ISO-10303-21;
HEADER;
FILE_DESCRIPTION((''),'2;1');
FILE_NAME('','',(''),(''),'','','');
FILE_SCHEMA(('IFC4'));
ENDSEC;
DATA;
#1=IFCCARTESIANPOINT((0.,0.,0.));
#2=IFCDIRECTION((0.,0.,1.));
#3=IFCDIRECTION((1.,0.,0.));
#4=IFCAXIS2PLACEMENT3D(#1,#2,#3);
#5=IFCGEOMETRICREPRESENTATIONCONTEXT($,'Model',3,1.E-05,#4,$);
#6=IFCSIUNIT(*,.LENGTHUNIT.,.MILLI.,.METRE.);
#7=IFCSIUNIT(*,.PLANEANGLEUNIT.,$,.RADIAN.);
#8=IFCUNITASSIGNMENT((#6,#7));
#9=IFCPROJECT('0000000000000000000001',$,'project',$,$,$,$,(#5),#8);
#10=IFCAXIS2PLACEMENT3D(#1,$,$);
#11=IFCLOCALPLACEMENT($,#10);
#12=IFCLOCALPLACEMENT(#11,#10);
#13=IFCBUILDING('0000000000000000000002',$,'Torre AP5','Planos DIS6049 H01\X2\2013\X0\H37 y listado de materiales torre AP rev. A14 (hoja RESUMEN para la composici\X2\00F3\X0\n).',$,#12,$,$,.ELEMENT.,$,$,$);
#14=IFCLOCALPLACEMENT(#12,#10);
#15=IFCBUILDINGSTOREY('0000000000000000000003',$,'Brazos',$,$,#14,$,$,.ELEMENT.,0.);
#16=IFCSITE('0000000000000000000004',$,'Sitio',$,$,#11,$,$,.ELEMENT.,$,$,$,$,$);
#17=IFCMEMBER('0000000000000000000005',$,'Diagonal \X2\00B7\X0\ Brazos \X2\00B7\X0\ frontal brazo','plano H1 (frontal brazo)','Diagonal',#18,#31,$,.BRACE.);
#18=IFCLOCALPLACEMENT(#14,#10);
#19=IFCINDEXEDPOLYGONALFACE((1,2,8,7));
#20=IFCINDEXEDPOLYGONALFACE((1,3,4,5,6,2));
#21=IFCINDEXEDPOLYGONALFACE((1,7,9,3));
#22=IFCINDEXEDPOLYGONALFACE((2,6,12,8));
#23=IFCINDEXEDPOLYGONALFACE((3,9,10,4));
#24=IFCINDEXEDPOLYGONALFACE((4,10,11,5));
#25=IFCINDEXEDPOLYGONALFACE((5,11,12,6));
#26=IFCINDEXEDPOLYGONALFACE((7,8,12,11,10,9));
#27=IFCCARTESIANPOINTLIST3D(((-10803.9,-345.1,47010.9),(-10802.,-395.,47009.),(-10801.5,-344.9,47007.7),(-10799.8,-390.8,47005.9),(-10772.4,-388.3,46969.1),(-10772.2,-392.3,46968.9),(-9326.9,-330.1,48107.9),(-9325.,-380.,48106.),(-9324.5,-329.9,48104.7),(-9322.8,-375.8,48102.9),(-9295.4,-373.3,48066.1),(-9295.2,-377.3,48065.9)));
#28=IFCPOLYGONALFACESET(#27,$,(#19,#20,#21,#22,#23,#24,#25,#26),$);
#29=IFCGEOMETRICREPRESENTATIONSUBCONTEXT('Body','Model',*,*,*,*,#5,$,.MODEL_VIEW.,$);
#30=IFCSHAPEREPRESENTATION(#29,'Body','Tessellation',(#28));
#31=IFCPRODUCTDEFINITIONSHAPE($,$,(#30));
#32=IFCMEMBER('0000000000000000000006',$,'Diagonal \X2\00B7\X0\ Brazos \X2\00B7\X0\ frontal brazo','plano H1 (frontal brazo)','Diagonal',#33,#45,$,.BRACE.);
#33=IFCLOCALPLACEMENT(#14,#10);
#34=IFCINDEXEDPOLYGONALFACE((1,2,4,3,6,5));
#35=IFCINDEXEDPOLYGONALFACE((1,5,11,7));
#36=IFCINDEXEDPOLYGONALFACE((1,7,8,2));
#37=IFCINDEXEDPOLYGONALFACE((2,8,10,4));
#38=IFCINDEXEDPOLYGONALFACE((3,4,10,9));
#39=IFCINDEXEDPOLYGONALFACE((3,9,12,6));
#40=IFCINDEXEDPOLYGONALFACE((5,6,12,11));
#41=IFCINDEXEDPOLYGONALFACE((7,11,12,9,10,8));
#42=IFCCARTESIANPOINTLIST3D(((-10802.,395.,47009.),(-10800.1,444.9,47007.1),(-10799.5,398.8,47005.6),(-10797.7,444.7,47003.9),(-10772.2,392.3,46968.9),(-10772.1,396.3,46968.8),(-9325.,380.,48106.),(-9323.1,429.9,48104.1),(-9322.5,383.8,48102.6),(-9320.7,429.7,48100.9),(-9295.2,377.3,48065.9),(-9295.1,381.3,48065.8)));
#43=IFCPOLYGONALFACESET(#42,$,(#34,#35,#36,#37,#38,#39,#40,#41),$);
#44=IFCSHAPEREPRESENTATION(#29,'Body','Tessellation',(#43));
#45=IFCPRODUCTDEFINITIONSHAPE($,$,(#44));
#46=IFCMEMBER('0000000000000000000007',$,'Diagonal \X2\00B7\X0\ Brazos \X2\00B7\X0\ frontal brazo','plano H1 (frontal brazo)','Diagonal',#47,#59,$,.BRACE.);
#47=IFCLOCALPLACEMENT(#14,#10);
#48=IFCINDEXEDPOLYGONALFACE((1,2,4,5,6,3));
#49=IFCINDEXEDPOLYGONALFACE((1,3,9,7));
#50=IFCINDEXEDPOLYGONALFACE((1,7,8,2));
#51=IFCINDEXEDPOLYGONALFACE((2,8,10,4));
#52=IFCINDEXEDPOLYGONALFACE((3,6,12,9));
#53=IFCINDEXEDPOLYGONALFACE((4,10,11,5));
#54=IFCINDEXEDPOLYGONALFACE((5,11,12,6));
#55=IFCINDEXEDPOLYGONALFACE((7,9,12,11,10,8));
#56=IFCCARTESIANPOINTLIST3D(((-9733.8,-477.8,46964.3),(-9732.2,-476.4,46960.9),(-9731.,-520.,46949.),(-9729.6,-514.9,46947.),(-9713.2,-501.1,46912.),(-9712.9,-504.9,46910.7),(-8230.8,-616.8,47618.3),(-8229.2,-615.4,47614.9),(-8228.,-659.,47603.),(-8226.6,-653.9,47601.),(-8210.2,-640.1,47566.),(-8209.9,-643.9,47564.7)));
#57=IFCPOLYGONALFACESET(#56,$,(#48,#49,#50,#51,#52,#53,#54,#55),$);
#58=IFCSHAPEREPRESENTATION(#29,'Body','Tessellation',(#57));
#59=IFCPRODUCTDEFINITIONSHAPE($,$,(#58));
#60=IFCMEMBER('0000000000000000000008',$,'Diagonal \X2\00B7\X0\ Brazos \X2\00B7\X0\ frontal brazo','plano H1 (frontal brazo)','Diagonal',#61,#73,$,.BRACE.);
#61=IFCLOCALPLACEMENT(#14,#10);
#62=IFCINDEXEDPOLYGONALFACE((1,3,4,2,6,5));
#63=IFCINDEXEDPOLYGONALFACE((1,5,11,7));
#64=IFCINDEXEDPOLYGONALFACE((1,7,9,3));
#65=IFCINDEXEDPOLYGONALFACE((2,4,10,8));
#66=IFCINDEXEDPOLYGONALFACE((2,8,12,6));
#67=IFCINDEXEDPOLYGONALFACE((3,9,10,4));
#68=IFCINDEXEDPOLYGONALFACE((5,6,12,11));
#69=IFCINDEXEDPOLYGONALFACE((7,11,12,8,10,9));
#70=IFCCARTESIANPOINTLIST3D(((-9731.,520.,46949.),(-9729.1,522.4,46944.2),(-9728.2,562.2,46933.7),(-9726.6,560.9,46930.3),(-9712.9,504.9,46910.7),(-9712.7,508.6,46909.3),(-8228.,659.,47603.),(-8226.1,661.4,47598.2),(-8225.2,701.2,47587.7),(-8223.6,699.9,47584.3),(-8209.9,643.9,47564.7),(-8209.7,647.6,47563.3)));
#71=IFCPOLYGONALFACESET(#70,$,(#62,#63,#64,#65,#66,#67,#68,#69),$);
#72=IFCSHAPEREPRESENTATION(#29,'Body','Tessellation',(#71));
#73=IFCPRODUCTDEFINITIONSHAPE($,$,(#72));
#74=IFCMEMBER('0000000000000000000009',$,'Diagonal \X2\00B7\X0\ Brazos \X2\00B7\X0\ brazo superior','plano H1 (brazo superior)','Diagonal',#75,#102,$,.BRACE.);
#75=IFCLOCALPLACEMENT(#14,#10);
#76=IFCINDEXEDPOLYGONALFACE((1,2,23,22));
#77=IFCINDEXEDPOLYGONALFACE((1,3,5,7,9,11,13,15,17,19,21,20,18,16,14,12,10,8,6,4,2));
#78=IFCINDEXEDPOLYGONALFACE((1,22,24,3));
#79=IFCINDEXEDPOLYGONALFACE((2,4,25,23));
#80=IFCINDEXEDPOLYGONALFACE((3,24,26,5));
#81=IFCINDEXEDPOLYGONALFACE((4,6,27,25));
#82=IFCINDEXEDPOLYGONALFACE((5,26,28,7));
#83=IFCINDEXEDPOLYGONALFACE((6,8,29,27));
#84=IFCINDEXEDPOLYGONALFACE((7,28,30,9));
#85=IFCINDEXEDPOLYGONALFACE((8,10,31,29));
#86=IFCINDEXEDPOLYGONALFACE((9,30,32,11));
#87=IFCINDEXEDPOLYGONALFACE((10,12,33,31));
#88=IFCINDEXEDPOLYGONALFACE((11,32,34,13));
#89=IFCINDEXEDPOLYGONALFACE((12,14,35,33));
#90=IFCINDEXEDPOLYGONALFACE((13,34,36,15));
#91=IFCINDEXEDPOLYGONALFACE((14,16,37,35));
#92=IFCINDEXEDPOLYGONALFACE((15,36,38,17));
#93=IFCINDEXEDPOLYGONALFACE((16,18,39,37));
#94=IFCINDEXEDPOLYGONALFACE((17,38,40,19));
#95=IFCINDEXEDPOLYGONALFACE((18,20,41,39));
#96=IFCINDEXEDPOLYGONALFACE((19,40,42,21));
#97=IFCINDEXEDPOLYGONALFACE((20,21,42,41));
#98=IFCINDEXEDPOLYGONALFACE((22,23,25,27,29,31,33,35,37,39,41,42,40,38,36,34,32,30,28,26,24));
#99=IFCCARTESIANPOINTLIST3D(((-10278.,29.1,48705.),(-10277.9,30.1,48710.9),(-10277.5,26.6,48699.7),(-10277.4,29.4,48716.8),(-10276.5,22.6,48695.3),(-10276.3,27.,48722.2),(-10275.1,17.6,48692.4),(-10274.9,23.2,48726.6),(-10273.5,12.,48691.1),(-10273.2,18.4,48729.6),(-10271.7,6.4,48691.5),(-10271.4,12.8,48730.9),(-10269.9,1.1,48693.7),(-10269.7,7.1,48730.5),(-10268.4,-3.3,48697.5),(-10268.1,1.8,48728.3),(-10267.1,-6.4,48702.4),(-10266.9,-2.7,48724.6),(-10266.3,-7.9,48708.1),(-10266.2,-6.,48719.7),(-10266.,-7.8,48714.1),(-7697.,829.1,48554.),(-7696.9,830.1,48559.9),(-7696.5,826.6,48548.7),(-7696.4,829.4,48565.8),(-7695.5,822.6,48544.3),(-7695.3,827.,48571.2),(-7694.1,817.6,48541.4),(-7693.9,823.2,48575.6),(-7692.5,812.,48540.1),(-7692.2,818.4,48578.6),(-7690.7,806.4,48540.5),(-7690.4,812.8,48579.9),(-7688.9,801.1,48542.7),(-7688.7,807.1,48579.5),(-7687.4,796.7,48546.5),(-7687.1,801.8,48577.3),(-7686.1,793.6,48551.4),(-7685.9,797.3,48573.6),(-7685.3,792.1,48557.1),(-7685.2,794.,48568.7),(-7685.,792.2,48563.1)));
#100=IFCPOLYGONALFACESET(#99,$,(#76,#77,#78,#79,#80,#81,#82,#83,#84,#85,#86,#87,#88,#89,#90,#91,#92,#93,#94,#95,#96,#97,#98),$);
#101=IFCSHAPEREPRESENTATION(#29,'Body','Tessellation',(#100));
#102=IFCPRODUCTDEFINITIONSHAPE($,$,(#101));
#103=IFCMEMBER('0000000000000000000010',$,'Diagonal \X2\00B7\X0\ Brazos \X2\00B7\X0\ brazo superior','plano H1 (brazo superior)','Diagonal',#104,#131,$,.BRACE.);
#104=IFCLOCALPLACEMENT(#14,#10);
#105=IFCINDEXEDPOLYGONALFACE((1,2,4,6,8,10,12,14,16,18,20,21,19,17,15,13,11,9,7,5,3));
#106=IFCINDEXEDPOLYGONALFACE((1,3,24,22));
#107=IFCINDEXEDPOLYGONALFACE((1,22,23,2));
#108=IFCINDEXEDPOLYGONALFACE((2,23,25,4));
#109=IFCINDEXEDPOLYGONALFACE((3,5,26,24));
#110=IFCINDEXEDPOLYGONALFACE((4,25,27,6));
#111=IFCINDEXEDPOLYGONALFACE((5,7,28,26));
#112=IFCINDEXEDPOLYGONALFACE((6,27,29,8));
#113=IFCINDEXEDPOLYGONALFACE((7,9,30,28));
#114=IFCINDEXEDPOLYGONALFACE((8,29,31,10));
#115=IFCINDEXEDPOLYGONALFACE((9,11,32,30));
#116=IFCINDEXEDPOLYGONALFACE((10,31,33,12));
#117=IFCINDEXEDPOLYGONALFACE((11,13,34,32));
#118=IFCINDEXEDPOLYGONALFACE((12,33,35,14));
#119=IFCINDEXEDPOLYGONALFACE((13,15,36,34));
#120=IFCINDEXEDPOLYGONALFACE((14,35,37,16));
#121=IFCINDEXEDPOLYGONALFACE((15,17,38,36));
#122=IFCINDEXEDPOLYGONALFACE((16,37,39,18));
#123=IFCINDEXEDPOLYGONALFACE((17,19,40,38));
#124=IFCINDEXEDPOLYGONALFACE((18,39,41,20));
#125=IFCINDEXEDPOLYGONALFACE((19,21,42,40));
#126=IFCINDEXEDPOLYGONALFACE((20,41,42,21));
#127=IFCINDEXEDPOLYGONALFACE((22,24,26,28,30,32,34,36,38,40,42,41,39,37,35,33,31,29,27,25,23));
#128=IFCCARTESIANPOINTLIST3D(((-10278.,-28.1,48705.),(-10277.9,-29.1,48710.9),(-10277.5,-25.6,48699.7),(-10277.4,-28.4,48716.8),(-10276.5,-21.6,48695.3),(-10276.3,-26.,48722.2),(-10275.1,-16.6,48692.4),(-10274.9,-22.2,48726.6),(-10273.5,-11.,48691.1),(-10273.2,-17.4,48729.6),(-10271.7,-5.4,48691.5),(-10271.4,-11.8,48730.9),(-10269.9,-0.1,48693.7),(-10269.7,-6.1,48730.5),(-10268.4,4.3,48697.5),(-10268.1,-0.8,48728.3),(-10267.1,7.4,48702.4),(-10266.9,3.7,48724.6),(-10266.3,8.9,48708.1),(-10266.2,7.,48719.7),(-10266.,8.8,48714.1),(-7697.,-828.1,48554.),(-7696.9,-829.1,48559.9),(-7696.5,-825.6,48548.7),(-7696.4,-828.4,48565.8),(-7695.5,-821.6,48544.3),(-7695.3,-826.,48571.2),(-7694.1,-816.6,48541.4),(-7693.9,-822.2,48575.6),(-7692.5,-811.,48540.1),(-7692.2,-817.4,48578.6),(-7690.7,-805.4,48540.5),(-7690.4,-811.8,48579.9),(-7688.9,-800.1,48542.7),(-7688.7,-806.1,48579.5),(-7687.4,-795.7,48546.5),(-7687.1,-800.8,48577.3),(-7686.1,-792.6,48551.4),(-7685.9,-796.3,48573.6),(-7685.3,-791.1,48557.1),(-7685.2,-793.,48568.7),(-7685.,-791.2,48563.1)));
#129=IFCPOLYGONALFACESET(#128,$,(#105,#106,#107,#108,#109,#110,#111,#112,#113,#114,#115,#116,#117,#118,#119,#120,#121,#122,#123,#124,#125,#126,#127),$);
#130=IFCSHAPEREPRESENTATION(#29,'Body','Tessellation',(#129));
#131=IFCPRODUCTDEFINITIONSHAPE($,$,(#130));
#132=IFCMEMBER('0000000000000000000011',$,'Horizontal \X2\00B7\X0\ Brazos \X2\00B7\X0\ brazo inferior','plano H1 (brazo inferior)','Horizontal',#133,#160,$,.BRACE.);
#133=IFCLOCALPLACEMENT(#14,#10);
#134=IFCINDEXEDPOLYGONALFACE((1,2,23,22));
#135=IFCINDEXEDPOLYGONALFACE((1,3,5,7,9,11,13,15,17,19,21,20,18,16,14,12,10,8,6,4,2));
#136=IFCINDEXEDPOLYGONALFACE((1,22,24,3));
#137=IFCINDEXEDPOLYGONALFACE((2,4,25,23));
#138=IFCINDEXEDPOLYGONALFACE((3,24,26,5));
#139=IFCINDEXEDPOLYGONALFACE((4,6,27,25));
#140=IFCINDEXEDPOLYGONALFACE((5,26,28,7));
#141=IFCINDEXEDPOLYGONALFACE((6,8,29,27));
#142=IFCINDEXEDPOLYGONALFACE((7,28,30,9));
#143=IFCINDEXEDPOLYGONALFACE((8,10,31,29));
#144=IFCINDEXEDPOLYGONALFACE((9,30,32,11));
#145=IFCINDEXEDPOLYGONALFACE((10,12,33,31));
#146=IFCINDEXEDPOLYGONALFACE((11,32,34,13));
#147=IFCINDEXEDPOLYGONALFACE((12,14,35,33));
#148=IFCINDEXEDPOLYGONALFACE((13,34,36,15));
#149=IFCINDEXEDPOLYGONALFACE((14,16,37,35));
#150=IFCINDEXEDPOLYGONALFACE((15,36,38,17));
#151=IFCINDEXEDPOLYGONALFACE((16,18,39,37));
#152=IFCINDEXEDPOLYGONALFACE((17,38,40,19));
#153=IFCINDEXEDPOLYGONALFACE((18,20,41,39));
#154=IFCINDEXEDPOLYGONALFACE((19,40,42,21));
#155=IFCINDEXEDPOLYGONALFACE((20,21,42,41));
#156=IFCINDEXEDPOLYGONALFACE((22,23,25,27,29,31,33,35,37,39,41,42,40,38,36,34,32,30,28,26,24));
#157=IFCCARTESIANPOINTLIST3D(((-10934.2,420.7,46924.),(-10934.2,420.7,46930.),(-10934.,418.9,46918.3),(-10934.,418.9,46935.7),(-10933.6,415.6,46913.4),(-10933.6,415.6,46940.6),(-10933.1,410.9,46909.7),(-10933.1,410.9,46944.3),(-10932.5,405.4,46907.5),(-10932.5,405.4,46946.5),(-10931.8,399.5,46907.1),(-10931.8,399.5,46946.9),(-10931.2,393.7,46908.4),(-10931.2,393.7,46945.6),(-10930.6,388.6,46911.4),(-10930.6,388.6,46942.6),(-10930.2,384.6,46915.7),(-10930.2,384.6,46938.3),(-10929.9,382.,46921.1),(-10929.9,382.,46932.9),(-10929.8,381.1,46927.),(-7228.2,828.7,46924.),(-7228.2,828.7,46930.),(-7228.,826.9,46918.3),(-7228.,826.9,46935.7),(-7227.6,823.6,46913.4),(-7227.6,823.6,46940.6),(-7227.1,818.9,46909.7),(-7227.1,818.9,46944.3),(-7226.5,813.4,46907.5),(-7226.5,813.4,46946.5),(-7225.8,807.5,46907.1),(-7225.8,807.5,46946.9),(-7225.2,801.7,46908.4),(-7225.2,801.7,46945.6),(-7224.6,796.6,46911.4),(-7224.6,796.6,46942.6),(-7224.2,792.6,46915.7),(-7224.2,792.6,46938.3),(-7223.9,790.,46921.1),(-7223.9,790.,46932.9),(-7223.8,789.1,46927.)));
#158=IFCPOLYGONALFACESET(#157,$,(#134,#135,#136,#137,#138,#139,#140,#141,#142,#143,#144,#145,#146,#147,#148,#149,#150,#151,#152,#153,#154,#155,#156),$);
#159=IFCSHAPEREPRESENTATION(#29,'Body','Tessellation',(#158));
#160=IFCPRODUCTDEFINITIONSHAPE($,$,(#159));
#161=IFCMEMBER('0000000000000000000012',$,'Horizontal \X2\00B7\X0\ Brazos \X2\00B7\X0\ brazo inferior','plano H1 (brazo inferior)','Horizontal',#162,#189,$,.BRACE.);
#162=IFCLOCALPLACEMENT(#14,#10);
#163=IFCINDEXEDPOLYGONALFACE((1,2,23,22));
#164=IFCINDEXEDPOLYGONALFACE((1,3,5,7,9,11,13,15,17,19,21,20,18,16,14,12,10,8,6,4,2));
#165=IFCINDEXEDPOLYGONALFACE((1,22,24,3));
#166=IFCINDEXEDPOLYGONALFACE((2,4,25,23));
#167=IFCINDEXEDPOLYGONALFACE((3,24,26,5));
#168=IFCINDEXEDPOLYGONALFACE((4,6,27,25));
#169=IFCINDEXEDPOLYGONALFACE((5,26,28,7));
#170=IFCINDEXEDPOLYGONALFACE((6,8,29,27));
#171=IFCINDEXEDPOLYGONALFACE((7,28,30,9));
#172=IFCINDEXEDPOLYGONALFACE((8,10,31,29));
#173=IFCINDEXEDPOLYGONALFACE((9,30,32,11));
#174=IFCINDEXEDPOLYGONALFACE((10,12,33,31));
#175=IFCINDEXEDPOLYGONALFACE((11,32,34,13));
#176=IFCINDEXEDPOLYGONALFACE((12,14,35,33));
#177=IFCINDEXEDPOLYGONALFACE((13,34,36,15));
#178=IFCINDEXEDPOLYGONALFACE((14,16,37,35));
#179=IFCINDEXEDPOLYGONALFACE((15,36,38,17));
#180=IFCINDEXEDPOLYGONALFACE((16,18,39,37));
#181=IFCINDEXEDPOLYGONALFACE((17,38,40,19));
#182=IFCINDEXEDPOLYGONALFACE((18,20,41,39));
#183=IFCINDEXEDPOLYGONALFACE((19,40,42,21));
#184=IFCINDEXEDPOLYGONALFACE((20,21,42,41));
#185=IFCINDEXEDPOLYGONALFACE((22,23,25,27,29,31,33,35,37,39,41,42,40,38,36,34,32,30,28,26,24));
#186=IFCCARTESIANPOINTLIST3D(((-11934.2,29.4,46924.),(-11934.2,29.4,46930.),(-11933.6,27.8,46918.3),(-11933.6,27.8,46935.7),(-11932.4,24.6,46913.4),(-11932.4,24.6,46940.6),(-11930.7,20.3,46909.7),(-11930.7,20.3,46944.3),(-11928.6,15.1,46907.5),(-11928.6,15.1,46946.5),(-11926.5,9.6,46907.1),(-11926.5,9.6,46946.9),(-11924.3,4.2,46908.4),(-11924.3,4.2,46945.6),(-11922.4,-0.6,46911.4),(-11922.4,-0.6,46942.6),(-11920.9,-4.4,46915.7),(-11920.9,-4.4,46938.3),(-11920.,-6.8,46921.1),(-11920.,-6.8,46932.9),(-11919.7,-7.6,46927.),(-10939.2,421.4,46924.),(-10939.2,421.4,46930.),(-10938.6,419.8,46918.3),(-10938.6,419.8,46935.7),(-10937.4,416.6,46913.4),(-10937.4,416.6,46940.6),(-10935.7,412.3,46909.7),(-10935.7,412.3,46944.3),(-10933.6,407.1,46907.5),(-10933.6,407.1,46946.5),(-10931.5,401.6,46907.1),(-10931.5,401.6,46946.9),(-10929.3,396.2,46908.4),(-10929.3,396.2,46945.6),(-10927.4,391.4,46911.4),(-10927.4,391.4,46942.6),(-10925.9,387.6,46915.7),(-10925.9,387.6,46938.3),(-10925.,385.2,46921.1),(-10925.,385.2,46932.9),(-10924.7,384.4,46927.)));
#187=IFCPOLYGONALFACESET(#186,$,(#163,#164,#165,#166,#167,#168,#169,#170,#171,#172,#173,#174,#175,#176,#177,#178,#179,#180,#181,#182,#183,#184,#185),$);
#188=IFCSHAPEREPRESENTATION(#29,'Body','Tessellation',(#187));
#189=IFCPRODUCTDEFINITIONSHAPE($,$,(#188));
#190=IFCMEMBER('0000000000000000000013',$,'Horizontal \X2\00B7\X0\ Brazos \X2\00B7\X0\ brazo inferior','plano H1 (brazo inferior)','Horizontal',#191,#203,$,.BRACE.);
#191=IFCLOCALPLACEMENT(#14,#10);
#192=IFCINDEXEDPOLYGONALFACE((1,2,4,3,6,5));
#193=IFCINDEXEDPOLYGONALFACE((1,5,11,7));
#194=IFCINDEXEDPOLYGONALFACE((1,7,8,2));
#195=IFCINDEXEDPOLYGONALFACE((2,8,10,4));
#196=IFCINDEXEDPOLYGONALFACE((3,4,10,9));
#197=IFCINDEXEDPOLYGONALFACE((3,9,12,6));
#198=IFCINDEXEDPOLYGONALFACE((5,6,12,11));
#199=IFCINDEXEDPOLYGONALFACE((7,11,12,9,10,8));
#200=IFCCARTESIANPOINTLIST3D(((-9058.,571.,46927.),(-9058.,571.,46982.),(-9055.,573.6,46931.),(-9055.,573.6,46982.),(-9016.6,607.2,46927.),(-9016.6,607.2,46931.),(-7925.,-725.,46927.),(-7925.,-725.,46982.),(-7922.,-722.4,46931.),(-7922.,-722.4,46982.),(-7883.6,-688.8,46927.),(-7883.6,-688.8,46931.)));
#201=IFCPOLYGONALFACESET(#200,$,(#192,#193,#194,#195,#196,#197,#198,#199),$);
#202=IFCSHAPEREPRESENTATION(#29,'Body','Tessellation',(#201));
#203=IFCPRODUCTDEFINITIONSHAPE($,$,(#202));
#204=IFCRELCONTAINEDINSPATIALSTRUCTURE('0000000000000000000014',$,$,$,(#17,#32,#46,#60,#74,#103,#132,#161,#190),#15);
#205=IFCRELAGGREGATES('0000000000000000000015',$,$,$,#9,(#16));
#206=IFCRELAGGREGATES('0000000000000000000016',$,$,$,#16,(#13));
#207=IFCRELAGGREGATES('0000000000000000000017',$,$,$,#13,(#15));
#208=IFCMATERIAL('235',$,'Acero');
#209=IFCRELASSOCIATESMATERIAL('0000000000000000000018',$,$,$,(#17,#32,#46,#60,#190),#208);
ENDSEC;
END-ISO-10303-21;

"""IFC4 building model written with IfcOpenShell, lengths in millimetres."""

from ifc_helpers import new_model, si_unit, frame, frame_2d, origin, origin_with_axes, place, context, subcontext, project, spatial, circle, l_section, extrude, material, element, save


model = new_model("IFC4")

# Units and contexts
model_context = context("Model", 3, precision=1e-05, world=origin_with_axes())
body_context = subcontext(model_context, "Body", "Model", "MODEL_VIEW")
ifc_project = project(units=[si_unit("LENGTHUNIT", "METRE", prefix="MILLI"), si_unit("PLANEANGLEUNIT", "RADIAN")], contexts=[model_context])

# Site, building, storey
site_placement = place(None, origin())
site = spatial("IfcSite", under=ifc_project, at=site_placement, Name="Sitio", CompositionType="ELEMENT")
building_placement = place(site_placement, origin())
building = spatial("IfcBuilding", under=site, at=building_placement, Name="Torre AP5", Description="Planos DIS6049 H01–H37 y listado de materiales torre AP rev. A14 (hoja RESUMEN para la composición).", CompositionType="ELEMENT")
storey_placement = place(building_placement, origin())
storey = spatial("IfcBuildingStorey", under=building, at=storey_placement, Name="Brazos", CompositionType="ELEMENT", Elevation=0.0)

# Members
ifc_material_1 = material(Name="235", Category="Acero")
for number, where, z_axis, x_axis, name in (
    (1, (-10802.0, -395.0, 47009.0), (0.802769, 0.008153, 0.596234), (0.595049, 0.053521, -0.801905), "Diagonal · Brazos · frontal brazo"),
    (2, (-10802.0, 395.0, 47009.0), (0.802769, -0.008153, 0.596234), (0.595049, -0.053521, -0.801905), "Diagonal · Brazos · frontal brazo"),
):
    element("IfcMember", number, at=place(storey_placement, frame(where, z_axis=z_axis, x_axis=x_axis)), inside=storey, material=ifc_material_1, Name=name, Description="plano H1 (frontal brazo)", ObjectType="Diagonal", PredefinedType="BRACE", context=body_context, shape_type="SweptSolid", body=[
        extrude(l_section(Depth=50.0, Width=50.0, Thickness=4.0, at=frame_2d((25.0, 25.0))), None, (0.0, 0.0, 1.0), 1839.9),
    ])
for number, where, z_axis, x_axis, name in (
    (3, (-9731.0, -520.0, 46949.0), (0.913674, -0.084498, 0.397567), (0.401755, 0.335963, -0.851893), "Diagonal · Brazos · frontal brazo"),
    (4, (-9731.0, 520.0, 46949.0), (0.913674, 0.084498, 0.397567), (0.401755, -0.335963, -0.851893), "Diagonal · Brazos · frontal brazo"),
):
    element("IfcMember", number, at=place(storey_placement, frame(where, z_axis=z_axis, x_axis=x_axis)), inside=storey, material=ifc_material_1, Name=name, Description="plano H1 (frontal brazo)", ObjectType="Diagonal", PredefinedType="BRACE", context=body_context, shape_type="SweptSolid", body=[
        extrude(l_section(Depth=45.0, Width=45.0, Thickness=4.0, at=frame_2d((22.5, 22.5))), None, (0.0, 0.0, 1.0), 1645.0),
    ])
for number, where, z_axis, x_axis, name in (
    (5, (-7691.0, 811.0, 48560.0), (-0.953681, -0.2956, 0.055795), (0.300728, -0.941427, 0.152572), "Diagonal · Brazos · brazo superior"),
    (6, (-10272.0, -10.0, 48711.0), (0.953681, -0.2956, -0.055795), (0.300729, 0.941418, 0.152624), "Diagonal · Brazos · brazo superior"),
):
    element("IfcMember", number, at=place(storey_placement, frame(where, z_axis=z_axis, x_axis=x_axis)), inside=storey, Name=name, Description="plano H1 (brazo superior)", ObjectType="Diagonal", PredefinedType="BRACE", context=body_context, shape_type="SweptSolid", body=[
        extrude(circle(Radius=20.0), None, (0.0, 0.0, 1.0), 2706.4),
    ])
member_1_placement = place(storey_placement, frame((-7226.0, 809.0, 46927.0), z_axis=(-0.993994, -0.109431, 0.0), x_axis=(0.109431, -0.993994, 0.0)))
element("IfcMember", 7, at=member_1_placement, inside=storey, Name="Horizontal · Brazos · brazo inferior", Description="plano H1 (brazo inferior)", ObjectType="Horizontal", PredefinedType="BRACE", context=body_context, shape_type="SweptSolid", body=[
    extrude(circle(Radius=20.0), None, (0.0, 0.0, 1.0), 3728.4),
])
member_2_placement = place(storey_placement, frame((-10932.0, 403.0, 46927.0), z_axis=(-0.930399, -0.366549, 0.0), x_axis=(0.366549, -0.930399, 0.0)))
element("IfcMember", 8, at=member_2_placement, inside=storey, Name="Horizontal · Brazos · brazo inferior", Description="plano H1 (brazo inferior)", ObjectType="Horizontal", PredefinedType="BRACE", context=body_context, shape_type="SweptSolid", body=[
    extrude(circle(Radius=20.0), None, (0.0, 0.0, 1.0), 1069.4),
])
member_3_placement = place(storey_placement, frame((-9058.0, 571.0, 46927.0), z_axis=(0.658176, -0.752865, 0.0), x_axis=(0.752865, 0.658176, 0.0)))
element("IfcMember", 9, at=member_3_placement, inside=storey, material=ifc_material_1, Name="Horizontal · Brazos · brazo inferior", Description="plano H1 (brazo inferior)", ObjectType="Horizontal", PredefinedType="BRACE", context=body_context, shape_type="SweptSolid", body=[
    extrude(l_section(Depth=55.0, Width=55.0, Thickness=4.0, at=frame_2d((27.5, 27.5))), None, (0.0, 0.0, 1.0), 1721.4),
])

save(model, "model.ifc")
